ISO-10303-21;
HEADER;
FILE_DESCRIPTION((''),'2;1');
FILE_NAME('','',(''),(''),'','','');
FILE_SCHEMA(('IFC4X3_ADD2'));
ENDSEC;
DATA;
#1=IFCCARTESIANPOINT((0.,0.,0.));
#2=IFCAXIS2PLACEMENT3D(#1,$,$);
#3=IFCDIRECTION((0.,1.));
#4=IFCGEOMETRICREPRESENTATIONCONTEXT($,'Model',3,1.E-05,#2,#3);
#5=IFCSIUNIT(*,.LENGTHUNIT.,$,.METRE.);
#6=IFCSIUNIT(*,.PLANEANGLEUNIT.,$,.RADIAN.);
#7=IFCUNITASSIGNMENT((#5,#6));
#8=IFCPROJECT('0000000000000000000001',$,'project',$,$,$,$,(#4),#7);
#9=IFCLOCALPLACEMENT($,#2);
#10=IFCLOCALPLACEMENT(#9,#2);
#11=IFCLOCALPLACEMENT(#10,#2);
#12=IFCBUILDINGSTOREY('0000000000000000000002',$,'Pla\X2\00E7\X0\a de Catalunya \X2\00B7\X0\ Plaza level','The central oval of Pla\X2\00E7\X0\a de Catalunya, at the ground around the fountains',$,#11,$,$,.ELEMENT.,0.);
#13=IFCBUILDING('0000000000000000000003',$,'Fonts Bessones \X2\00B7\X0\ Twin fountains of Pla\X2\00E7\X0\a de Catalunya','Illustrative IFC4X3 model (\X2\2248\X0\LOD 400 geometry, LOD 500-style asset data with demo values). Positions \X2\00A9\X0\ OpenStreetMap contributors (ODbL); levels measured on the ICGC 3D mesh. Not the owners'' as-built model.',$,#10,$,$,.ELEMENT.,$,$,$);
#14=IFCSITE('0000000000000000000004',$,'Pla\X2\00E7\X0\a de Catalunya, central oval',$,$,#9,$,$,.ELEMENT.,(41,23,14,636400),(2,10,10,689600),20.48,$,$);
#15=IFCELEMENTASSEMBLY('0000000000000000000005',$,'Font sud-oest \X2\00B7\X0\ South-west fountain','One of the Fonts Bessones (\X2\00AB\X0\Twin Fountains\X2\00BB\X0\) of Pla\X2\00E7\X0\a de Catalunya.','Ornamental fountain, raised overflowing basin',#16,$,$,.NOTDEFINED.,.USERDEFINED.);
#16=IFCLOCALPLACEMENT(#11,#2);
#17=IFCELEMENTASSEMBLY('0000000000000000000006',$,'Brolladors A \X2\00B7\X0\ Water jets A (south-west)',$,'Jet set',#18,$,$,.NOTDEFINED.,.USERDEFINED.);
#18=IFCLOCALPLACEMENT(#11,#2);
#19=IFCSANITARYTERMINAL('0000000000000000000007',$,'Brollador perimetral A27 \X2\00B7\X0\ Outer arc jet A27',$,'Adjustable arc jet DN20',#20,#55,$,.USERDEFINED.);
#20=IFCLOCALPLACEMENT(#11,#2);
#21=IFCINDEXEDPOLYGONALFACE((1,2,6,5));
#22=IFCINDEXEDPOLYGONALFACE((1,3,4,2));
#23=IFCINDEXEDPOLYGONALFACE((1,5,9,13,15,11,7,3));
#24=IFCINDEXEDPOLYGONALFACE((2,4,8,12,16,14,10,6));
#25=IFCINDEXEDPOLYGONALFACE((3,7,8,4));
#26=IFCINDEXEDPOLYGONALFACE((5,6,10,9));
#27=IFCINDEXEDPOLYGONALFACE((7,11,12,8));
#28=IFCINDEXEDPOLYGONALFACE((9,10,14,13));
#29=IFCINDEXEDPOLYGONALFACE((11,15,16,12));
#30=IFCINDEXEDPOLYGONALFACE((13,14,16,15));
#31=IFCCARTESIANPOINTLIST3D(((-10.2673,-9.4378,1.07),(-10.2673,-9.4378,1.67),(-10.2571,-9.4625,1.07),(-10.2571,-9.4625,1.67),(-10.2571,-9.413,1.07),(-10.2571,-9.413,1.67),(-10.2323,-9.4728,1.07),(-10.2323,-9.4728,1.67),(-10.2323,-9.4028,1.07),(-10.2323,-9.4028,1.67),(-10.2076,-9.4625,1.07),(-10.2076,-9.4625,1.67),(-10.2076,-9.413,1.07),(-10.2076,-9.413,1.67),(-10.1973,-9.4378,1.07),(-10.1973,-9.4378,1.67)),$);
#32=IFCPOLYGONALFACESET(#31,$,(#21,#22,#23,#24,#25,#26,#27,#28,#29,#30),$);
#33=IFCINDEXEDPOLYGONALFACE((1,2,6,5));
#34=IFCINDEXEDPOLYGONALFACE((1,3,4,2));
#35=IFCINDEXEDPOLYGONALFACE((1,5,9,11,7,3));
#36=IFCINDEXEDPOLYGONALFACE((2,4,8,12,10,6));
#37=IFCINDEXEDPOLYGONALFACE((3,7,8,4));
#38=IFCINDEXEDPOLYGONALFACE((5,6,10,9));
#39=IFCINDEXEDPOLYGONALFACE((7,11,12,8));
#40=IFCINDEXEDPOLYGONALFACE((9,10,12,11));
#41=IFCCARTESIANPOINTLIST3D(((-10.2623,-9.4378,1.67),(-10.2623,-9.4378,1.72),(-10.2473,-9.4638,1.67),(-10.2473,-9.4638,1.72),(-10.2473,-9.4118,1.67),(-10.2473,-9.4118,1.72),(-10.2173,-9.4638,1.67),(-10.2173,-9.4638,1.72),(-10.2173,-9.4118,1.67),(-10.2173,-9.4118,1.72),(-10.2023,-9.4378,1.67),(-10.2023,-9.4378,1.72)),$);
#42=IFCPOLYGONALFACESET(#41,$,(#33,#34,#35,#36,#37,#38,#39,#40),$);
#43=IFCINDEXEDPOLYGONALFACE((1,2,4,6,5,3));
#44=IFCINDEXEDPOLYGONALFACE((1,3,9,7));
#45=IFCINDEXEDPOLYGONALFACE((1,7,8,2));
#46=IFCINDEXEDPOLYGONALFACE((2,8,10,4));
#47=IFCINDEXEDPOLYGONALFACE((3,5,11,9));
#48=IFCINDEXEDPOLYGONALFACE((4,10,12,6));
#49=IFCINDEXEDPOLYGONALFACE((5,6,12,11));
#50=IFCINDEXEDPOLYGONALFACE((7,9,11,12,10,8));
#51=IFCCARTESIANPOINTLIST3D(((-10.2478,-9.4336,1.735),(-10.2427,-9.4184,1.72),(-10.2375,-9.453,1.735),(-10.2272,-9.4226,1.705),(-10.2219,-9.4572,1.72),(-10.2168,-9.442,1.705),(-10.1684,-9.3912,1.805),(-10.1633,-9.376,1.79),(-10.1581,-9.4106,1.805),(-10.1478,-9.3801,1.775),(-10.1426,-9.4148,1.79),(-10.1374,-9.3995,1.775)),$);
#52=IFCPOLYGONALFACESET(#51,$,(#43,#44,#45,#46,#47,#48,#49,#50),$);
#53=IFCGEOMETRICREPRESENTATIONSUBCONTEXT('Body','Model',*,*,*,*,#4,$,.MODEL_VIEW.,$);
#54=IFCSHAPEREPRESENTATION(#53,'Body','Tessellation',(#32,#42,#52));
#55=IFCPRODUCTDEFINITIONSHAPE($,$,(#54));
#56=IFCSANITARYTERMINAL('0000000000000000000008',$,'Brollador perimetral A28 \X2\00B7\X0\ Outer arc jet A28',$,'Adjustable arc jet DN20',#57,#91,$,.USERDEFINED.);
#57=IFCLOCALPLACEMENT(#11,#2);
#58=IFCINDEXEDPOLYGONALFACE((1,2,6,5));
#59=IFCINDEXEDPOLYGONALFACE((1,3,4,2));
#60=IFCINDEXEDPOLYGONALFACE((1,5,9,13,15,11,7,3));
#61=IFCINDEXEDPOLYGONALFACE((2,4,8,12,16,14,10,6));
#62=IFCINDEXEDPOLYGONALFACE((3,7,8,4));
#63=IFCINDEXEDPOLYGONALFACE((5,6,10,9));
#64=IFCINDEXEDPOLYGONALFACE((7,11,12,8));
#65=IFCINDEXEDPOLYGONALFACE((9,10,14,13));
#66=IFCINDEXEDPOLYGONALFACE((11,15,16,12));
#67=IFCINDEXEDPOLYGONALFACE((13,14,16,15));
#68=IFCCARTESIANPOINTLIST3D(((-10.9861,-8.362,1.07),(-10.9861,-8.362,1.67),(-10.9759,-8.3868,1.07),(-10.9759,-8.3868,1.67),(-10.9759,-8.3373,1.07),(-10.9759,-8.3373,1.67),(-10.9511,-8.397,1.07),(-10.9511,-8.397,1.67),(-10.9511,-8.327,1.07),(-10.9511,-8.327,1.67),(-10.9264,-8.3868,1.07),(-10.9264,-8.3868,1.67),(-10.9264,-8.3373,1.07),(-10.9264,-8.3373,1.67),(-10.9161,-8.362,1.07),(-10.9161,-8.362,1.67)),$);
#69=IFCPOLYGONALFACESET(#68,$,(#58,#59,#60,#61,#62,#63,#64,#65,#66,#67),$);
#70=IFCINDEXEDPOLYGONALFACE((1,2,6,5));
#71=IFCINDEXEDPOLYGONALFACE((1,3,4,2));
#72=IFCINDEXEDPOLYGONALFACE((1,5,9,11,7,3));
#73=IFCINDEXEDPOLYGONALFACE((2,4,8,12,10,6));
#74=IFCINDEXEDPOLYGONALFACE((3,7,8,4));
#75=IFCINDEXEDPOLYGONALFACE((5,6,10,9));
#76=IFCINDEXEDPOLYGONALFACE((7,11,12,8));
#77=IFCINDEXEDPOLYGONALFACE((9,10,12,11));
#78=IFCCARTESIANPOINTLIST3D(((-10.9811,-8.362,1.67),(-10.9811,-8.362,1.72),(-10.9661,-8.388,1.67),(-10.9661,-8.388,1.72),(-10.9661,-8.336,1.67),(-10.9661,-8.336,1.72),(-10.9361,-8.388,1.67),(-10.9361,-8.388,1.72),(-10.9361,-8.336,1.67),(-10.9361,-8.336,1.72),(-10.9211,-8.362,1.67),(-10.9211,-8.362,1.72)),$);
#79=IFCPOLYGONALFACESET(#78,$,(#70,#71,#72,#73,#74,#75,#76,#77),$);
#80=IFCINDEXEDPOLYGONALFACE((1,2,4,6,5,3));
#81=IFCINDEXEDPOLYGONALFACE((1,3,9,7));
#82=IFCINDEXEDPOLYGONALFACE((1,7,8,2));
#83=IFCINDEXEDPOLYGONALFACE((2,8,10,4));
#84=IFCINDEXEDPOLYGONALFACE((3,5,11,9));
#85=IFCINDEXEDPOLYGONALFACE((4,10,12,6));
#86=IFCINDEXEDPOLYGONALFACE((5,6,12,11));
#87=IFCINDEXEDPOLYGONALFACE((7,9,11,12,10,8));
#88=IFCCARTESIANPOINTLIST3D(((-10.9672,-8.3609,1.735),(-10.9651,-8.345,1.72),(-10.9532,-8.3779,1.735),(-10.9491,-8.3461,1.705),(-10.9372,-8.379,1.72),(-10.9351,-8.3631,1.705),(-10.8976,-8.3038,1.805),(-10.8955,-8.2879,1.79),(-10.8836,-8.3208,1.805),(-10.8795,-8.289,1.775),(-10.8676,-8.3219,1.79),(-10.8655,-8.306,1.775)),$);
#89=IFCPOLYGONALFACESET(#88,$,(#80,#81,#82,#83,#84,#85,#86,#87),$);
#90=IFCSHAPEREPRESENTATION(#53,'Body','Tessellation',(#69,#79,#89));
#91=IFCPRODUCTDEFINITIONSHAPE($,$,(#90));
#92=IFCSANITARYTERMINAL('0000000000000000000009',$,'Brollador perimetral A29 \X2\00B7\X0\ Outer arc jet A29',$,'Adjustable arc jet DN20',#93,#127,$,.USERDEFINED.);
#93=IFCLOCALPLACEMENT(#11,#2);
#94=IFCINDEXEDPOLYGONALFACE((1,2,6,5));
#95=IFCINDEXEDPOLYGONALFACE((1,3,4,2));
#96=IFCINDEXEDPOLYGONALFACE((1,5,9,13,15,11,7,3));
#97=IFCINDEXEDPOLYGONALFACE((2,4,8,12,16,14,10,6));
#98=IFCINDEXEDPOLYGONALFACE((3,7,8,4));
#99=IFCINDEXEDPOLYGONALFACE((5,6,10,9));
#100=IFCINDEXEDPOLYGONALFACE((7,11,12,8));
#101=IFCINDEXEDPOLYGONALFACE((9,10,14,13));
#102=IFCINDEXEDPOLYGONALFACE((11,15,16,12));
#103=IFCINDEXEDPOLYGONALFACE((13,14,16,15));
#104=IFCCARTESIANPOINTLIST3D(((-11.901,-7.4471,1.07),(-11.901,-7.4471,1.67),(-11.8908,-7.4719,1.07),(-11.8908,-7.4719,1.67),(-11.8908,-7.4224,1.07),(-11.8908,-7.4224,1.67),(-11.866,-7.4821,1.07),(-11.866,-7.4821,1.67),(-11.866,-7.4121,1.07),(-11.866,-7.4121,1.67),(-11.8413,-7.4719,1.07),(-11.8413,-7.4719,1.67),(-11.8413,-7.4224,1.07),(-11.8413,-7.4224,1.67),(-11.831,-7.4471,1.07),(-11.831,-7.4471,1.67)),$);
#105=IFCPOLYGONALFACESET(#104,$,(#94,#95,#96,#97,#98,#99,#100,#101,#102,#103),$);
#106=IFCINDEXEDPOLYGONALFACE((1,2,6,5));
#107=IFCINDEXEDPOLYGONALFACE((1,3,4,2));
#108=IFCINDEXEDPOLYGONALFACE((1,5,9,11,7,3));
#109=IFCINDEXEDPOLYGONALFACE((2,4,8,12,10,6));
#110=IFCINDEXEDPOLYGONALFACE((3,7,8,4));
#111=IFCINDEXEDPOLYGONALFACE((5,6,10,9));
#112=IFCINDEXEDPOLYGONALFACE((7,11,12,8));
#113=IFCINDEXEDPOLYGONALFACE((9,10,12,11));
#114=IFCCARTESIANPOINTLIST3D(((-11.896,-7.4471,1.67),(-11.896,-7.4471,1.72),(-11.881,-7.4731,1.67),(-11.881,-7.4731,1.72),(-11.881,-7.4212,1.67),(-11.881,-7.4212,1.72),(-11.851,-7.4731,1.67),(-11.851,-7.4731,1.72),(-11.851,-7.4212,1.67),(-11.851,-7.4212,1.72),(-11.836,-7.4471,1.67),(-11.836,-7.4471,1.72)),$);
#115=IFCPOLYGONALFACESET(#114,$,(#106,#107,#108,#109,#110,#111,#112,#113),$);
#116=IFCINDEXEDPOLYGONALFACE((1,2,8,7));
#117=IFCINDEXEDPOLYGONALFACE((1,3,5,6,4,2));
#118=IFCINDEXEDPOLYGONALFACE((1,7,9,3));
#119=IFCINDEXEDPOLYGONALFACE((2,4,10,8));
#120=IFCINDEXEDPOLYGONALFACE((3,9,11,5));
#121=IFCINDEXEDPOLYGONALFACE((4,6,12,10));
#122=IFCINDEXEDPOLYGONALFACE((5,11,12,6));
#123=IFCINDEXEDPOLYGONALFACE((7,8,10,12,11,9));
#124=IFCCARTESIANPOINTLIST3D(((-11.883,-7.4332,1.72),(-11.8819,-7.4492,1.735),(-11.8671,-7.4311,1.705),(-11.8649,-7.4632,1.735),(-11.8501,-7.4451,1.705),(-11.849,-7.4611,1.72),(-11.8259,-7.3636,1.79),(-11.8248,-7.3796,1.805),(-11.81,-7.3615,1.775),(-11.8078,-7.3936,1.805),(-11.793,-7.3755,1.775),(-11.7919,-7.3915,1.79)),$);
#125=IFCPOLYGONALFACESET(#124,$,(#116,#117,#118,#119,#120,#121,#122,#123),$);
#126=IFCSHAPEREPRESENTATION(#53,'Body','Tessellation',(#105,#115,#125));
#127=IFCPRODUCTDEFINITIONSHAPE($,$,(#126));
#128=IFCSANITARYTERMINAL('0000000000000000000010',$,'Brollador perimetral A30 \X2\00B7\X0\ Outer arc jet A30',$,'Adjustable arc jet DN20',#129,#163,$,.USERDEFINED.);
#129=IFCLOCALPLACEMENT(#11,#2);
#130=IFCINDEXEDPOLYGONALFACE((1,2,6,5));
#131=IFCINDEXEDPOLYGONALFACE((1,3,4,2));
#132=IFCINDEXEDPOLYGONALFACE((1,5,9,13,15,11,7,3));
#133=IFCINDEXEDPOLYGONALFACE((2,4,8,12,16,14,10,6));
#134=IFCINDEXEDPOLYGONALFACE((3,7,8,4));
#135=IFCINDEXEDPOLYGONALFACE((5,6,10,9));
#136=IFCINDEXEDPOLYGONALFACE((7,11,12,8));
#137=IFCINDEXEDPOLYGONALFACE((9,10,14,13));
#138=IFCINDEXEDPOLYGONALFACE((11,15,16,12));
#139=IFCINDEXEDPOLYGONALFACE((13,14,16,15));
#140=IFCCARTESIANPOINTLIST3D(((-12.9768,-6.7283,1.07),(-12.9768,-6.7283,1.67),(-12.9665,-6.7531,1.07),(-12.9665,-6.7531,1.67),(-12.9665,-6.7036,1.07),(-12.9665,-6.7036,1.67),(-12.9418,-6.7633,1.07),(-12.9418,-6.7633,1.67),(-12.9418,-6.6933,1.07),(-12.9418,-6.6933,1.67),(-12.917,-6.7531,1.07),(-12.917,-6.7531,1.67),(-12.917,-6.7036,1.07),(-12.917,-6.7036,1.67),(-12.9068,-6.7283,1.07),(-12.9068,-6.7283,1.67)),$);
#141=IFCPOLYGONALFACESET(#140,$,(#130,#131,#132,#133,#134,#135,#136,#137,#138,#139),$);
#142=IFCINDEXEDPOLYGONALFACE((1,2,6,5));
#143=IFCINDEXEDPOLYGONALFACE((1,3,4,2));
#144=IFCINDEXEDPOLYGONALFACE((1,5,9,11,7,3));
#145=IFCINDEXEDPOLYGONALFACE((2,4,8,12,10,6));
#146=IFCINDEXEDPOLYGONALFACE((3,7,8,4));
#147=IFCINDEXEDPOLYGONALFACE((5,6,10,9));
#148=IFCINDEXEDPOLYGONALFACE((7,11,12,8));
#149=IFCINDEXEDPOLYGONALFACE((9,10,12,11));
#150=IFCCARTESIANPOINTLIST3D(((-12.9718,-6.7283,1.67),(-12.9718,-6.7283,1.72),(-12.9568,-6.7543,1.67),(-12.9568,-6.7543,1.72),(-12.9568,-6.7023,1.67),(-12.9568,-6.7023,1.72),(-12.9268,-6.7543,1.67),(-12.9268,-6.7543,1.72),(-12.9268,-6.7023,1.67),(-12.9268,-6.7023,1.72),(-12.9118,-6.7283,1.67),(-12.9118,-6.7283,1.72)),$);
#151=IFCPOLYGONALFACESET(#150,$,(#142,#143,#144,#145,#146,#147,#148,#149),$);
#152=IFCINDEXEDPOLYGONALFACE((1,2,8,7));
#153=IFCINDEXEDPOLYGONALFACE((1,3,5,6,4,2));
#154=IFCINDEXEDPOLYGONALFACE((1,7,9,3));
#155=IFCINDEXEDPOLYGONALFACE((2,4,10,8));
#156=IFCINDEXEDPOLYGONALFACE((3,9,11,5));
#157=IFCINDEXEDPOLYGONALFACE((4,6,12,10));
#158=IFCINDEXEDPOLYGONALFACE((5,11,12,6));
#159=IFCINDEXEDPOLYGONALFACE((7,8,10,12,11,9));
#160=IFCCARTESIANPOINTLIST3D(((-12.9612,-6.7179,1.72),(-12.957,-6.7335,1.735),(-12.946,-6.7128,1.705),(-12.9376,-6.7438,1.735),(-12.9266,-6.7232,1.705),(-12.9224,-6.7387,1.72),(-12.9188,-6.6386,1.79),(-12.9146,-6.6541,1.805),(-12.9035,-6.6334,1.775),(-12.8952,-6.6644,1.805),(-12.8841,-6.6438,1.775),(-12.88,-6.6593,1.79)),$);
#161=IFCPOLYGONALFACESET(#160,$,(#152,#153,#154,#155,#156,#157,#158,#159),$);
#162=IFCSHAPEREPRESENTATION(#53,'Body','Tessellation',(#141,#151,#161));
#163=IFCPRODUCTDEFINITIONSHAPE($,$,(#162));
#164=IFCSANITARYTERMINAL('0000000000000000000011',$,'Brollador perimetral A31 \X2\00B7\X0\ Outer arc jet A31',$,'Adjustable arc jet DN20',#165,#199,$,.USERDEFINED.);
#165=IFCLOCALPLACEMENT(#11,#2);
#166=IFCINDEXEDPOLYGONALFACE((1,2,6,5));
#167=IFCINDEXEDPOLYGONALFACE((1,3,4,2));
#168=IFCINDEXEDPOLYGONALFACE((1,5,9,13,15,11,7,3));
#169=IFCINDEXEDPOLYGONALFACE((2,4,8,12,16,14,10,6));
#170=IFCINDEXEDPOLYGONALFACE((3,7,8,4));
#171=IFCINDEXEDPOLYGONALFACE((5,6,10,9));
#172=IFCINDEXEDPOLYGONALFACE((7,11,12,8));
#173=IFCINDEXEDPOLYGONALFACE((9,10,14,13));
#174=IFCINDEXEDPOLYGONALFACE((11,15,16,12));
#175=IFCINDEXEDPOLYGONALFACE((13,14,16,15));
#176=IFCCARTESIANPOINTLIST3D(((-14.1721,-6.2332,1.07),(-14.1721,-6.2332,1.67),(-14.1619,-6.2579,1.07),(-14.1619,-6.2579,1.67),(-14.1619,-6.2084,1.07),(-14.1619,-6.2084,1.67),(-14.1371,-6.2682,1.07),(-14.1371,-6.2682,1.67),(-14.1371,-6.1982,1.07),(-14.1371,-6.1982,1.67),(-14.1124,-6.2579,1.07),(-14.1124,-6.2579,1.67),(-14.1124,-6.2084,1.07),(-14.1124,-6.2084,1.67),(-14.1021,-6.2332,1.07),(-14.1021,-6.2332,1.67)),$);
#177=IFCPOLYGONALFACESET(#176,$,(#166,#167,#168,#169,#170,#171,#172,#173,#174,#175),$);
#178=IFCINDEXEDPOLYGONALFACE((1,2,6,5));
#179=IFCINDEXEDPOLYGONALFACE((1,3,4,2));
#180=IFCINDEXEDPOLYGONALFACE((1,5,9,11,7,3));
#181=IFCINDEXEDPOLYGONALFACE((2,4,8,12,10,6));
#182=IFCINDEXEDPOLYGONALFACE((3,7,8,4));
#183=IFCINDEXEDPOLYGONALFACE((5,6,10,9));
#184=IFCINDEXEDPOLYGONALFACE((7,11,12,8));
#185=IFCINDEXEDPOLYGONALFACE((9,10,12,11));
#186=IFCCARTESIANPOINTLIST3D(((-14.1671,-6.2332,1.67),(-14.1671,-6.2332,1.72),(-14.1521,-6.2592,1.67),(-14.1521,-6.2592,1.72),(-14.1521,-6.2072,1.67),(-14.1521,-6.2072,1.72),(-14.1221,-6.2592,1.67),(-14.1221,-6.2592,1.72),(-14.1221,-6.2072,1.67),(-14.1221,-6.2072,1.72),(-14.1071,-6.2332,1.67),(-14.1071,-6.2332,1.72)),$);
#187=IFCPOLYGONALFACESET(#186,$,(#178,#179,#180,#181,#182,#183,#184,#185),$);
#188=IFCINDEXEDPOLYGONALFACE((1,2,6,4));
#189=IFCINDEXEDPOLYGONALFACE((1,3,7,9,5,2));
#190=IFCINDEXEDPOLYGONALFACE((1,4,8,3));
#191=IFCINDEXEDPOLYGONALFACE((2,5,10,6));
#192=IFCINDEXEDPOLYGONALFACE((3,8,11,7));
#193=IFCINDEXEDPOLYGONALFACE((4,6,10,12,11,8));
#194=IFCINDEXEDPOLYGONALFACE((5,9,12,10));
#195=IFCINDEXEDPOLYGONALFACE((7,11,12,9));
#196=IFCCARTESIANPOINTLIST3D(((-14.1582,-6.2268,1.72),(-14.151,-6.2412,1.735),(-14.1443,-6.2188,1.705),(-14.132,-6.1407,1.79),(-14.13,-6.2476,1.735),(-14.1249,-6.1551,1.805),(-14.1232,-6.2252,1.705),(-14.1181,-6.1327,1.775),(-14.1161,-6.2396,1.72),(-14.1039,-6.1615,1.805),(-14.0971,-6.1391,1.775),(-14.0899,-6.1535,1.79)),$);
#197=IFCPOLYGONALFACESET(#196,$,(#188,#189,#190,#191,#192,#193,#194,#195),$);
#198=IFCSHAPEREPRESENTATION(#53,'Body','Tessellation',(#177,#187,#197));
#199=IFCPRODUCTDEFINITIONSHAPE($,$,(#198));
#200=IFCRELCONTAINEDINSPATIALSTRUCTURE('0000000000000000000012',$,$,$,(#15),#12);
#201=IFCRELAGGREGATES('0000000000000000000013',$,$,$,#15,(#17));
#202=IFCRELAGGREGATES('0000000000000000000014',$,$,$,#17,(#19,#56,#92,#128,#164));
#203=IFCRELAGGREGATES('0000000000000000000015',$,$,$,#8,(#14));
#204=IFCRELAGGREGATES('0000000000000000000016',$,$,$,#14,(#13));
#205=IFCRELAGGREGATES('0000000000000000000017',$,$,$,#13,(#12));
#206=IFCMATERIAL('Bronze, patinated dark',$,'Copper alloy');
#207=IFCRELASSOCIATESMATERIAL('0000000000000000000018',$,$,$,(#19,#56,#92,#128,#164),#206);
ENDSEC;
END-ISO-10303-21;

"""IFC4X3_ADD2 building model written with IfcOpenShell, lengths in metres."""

from ifc_helpers import new_model, si_unit, direction, frame, origin, place, context, subcontext, project, spatial, polyline, outline, extrude, material, element, aggregate, save


model = new_model("IFC4X3_ADD2")

# Units and contexts
model_context = context("Model", 3, precision=1e-05, world=origin(), true_north=direction((0.0, 1.0)))
body_context = subcontext(model_context, "Body", "Model", "MODEL_VIEW")
ifc_project = project(units=[si_unit("LENGTHUNIT", "METRE"), si_unit("PLANEANGLEUNIT", "RADIAN")], contexts=[model_context])

# Site, building, storey
site_placement = place(None, origin())
site = spatial("IfcSite", under=ifc_project, at=site_placement, Name="Plaça de Catalunya, central oval", CompositionType="ELEMENT", RefLatitude=(41, 23, 14, 636400), RefLongitude=(2, 10, 10, 689600), RefElevation=20.48)
building_placement = place(site_placement, origin())
building = spatial("IfcBuilding", under=site, at=building_placement, Name="Fonts Bessones · Twin fountains of Plaça de Catalunya", Description="Illustrative IFC4X3 model (≈LOD 400 geometry, LOD 500-style asset data with demo values). Positions © OpenStreetMap contributors (ODbL); levels measured on the ICGC 3D mesh. Not the owners' as-built model.", CompositionType="ELEMENT")
storey_placement = place(building_placement, origin())
storey = spatial("IfcBuildingStorey", under=building, at=storey_placement, Name="Plaça de Catalunya · Plaza level", Description="The central oval of Plaça de Catalunya, at the ground around the fountains", CompositionType="ELEMENT", Elevation=0.0)

# Element assemblies, sanitary terminals
assembly_1_placement = place(building_placement, origin())
assembly_1 = element("IfcElementAssembly", 1, at=assembly_1_placement, inside=storey, Name="Font sud-oest · South-west fountain", Description="One of the Fonts Bessones («Twin Fountains») of Plaça de Catalunya.", ObjectType="Ornamental fountain, raised overflowing basin", AssemblyPlace="NOTDEFINED", PredefinedType="USERDEFINED")
assembly_2_placement = place(building_placement, origin())
assembly_2 = element("IfcElementAssembly", 2, at=assembly_2_placement, Name="Brolladors A · Water jets A (south-west)", ObjectType="Jet set", AssemblyPlace="NOTDEFINED", PredefinedType="USERDEFINED")
ifc_material_1 = material(Name="Bronze, patinated dark", Category="Copper alloy")
sanitary_terminal_1_placement = place(building_placement, origin())
sanitary_terminal_1 = element("IfcSanitaryTerminal", 3, at=sanitary_terminal_1_placement, material=ifc_material_1, Name="Brollador perimetral A27 · Outer arc jet A27", ObjectType="Adjustable arc jet DN20", PredefinedType="USERDEFINED", context=body_context, shape_type="SweptSolid", body=[
    extrude(outline(polyline([(-10.1973, -9.4378), (-10.2076, -9.413), (-10.2323, -9.4028), (-10.2571, -9.413), (-10.2673, -9.4378), (-10.2571, -9.4625), (-10.2323, -9.4728), (-10.2076, -9.4625), (-10.1973, -9.4378)])), frame((0.0, 0.0, 1.07)), (0.0, 0.0, 1.0), 0.6),
    extrude(outline(polyline([(-10.2023, -9.4378), (-10.2173, -9.4118), (-10.2473, -9.4118), (-10.2623, -9.4378), (-10.2473, -9.4638), (-10.2173, -9.4638), (-10.2023, -9.4378)])), frame((0.0, 0.0, 1.67)), (0.0, 0.0, 1.0), 0.05),
    extrude(outline(polyline([(0.022, 0.0), (0.011, 0.0191), (-0.011, 0.0191), (-0.022, 0.0), (-0.011, -0.0191), (0.011, -0.0191), (0.022, 0.0)])), frame((-10.2323, -9.4378, 1.72), z_axis=(0.696147, 0.372098, 0.613941), x_axis=(0.471397, -0.881921, 0.0)), (0.0, 0.0, 1.0), 0.114),
])
sanitary_terminal_2_placement = place(building_placement, origin())
sanitary_terminal_2 = element("IfcSanitaryTerminal", 4, at=sanitary_terminal_2_placement, material=ifc_material_1, Name="Brollador perimetral A28 · Outer arc jet A28", ObjectType="Adjustable arc jet DN20", PredefinedType="USERDEFINED", context=body_context, shape_type="SweptSolid", body=[
    extrude(outline(polyline([(-10.9161, -8.362), (-10.9264, -8.3373), (-10.9511, -8.327), (-10.9759, -8.3373), (-10.9861, -8.362), (-10.9759, -8.3868), (-10.9511, -8.397), (-10.9264, -8.3868), (-10.9161, -8.362)])), frame((0.0, 0.0, 1.07)), (0.0, 0.0, 1.0), 0.6),
    extrude(outline(polyline([(-10.9211, -8.362), (-10.9361, -8.336), (-10.9661, -8.336), (-10.9811, -8.362), (-10.9661, -8.388), (-10.9361, -8.388), (-10.9211, -8.362)])), frame((0.0, 0.0, 1.67)), (0.0, 0.0, 1.0), 0.05),
    extrude(outline(polyline([(0.022, 0.0), (0.011, 0.0191), (-0.011, 0.0191), (-0.022, 0.0), (-0.011, -0.0191), (0.011, -0.0191), (0.022, 0.0)])), frame((-10.9511, -8.362, 1.72), z_axis=(0.610178, 0.50076, 0.613941), x_axis=(0.634393, -0.77301, 0.0)), (0.0, 0.0, 1.0), 0.114),
])
sanitary_terminal_3_placement = place(building_placement, origin())
sanitary_terminal_3 = element("IfcSanitaryTerminal", 5, at=sanitary_terminal_3_placement, material=ifc_material_1, Name="Brollador perimetral A29 · Outer arc jet A29", ObjectType="Adjustable arc jet DN20", PredefinedType="USERDEFINED", context=body_context, shape_type="SweptSolid", body=[
    extrude(outline(polyline([(-11.831, -7.4471), (-11.8413, -7.4224), (-11.866, -7.4121), (-11.8908, -7.4224), (-11.901, -7.4471), (-11.8908, -7.4719), (-11.866, -7.4821), (-11.8413, -7.4719), (-11.831, -7.4471)])), frame((0.0, 0.0, 1.07)), (0.0, 0.0, 1.0), 0.6),
    extrude(outline(polyline([(-11.836, -7.4471), (-11.851, -7.4212), (-11.881, -7.4212), (-11.896, -7.4471), (-11.881, -7.4731), (-11.851, -7.4731), (-11.836, -7.4471)])), frame((0.0, 0.0, 1.67)), (0.0, 0.0, 1.0), 0.05),
    extrude(outline(polyline([(0.022, 0.0), (0.011, 0.0191), (-0.011, 0.0191), (-0.022, 0.0), (-0.011, -0.0191), (0.011, -0.0191), (0.022, 0.0)])), frame((-11.866, -7.4471, 1.72), z_axis=(0.50076, 0.610178, 0.613941), x_axis=(0.77301, -0.634393, 0.0)), (0.0, 0.0, 1.0), 0.114),
])
sanitary_terminal_4_placement = place(building_placement, origin())
sanitary_terminal_4 = element("IfcSanitaryTerminal", 6, at=sanitary_terminal_4_placement, material=ifc_material_1, Name="Brollador perimetral A30 · Outer arc jet A30", ObjectType="Adjustable arc jet DN20", PredefinedType="USERDEFINED", context=body_context, shape_type="SweptSolid", body=[
    extrude(outline(polyline([(-12.9068, -6.7283), (-12.917, -6.7036), (-12.9418, -6.6933), (-12.9665, -6.7036), (-12.9768, -6.7283), (-12.9665, -6.7531), (-12.9418, -6.7633), (-12.917, -6.7531), (-12.9068, -6.7283)])), frame((0.0, 0.0, 1.07)), (0.0, 0.0, 1.0), 0.6),
    extrude(outline(polyline([(-12.9118, -6.7283), (-12.9268, -6.7023), (-12.9568, -6.7023), (-12.9718, -6.7283), (-12.9568, -6.7543), (-12.9268, -6.7543), (-12.9118, -6.7283)])), frame((0.0, 0.0, 1.67)), (0.0, 0.0, 1.0), 0.05),
    extrude(outline(polyline([(0.022, 0.0), (0.011, 0.0191), (-0.011, 0.0191), (-0.022, 0.0), (-0.011, -0.0191), (0.011, -0.0191), (0.022, 0.0)])), frame((-12.9418, -6.7283, 1.72), z_axis=(0.372098, 0.696147, 0.613941), x_axis=(0.881921, -0.471397, 0.0)), (0.0, 0.0, 1.0), 0.114),
])
sanitary_terminal_5_placement = place(building_placement, origin())
sanitary_terminal_5 = element("IfcSanitaryTerminal", 7, at=sanitary_terminal_5_placement, material=ifc_material_1, Name="Brollador perimetral A31 · Outer arc jet A31", ObjectType="Adjustable arc jet DN20", PredefinedType="USERDEFINED", context=body_context, shape_type="SweptSolid", body=[
    extrude(outline(polyline([(-14.1021, -6.2332), (-14.1124, -6.2084), (-14.1371, -6.1982), (-14.1619, -6.2084), (-14.1721, -6.2332), (-14.1619, -6.2579), (-14.1371, -6.2682), (-14.1124, -6.2579), (-14.1021, -6.2332)])), frame((0.0, 0.0, 1.07)), (0.0, 0.0, 1.0), 0.6),
    extrude(outline(polyline([(-14.1071, -6.2332), (-14.1221, -6.2072), (-14.1521, -6.2072), (-14.1671, -6.2332), (-14.1521, -6.2592), (-14.1221, -6.2592), (-14.1071, -6.2332)])), frame((0.0, 0.0, 1.67)), (0.0, 0.0, 1.0), 0.05),
    extrude(outline(polyline([(0.022, 0.0), (0.011, 0.0191), (-0.011, 0.0191), (-0.022, 0.0), (-0.011, -0.0191), (0.011, -0.0191), (0.022, 0.0)])), frame((-14.1371, -6.2332, 1.72), z_axis=(0.229137, 0.755363, 0.613941), x_axis=(0.95694, -0.290285, 0.0)), (0.0, 0.0, 1.0), 0.114),
])
aggregate(assembly_1, [assembly_2])
aggregate(assembly_2, [sanitary_terminal_1, sanitary_terminal_2, sanitary_terminal_3, sanitary_terminal_4, sanitary_terminal_5])

save(model, "model.ifc")
